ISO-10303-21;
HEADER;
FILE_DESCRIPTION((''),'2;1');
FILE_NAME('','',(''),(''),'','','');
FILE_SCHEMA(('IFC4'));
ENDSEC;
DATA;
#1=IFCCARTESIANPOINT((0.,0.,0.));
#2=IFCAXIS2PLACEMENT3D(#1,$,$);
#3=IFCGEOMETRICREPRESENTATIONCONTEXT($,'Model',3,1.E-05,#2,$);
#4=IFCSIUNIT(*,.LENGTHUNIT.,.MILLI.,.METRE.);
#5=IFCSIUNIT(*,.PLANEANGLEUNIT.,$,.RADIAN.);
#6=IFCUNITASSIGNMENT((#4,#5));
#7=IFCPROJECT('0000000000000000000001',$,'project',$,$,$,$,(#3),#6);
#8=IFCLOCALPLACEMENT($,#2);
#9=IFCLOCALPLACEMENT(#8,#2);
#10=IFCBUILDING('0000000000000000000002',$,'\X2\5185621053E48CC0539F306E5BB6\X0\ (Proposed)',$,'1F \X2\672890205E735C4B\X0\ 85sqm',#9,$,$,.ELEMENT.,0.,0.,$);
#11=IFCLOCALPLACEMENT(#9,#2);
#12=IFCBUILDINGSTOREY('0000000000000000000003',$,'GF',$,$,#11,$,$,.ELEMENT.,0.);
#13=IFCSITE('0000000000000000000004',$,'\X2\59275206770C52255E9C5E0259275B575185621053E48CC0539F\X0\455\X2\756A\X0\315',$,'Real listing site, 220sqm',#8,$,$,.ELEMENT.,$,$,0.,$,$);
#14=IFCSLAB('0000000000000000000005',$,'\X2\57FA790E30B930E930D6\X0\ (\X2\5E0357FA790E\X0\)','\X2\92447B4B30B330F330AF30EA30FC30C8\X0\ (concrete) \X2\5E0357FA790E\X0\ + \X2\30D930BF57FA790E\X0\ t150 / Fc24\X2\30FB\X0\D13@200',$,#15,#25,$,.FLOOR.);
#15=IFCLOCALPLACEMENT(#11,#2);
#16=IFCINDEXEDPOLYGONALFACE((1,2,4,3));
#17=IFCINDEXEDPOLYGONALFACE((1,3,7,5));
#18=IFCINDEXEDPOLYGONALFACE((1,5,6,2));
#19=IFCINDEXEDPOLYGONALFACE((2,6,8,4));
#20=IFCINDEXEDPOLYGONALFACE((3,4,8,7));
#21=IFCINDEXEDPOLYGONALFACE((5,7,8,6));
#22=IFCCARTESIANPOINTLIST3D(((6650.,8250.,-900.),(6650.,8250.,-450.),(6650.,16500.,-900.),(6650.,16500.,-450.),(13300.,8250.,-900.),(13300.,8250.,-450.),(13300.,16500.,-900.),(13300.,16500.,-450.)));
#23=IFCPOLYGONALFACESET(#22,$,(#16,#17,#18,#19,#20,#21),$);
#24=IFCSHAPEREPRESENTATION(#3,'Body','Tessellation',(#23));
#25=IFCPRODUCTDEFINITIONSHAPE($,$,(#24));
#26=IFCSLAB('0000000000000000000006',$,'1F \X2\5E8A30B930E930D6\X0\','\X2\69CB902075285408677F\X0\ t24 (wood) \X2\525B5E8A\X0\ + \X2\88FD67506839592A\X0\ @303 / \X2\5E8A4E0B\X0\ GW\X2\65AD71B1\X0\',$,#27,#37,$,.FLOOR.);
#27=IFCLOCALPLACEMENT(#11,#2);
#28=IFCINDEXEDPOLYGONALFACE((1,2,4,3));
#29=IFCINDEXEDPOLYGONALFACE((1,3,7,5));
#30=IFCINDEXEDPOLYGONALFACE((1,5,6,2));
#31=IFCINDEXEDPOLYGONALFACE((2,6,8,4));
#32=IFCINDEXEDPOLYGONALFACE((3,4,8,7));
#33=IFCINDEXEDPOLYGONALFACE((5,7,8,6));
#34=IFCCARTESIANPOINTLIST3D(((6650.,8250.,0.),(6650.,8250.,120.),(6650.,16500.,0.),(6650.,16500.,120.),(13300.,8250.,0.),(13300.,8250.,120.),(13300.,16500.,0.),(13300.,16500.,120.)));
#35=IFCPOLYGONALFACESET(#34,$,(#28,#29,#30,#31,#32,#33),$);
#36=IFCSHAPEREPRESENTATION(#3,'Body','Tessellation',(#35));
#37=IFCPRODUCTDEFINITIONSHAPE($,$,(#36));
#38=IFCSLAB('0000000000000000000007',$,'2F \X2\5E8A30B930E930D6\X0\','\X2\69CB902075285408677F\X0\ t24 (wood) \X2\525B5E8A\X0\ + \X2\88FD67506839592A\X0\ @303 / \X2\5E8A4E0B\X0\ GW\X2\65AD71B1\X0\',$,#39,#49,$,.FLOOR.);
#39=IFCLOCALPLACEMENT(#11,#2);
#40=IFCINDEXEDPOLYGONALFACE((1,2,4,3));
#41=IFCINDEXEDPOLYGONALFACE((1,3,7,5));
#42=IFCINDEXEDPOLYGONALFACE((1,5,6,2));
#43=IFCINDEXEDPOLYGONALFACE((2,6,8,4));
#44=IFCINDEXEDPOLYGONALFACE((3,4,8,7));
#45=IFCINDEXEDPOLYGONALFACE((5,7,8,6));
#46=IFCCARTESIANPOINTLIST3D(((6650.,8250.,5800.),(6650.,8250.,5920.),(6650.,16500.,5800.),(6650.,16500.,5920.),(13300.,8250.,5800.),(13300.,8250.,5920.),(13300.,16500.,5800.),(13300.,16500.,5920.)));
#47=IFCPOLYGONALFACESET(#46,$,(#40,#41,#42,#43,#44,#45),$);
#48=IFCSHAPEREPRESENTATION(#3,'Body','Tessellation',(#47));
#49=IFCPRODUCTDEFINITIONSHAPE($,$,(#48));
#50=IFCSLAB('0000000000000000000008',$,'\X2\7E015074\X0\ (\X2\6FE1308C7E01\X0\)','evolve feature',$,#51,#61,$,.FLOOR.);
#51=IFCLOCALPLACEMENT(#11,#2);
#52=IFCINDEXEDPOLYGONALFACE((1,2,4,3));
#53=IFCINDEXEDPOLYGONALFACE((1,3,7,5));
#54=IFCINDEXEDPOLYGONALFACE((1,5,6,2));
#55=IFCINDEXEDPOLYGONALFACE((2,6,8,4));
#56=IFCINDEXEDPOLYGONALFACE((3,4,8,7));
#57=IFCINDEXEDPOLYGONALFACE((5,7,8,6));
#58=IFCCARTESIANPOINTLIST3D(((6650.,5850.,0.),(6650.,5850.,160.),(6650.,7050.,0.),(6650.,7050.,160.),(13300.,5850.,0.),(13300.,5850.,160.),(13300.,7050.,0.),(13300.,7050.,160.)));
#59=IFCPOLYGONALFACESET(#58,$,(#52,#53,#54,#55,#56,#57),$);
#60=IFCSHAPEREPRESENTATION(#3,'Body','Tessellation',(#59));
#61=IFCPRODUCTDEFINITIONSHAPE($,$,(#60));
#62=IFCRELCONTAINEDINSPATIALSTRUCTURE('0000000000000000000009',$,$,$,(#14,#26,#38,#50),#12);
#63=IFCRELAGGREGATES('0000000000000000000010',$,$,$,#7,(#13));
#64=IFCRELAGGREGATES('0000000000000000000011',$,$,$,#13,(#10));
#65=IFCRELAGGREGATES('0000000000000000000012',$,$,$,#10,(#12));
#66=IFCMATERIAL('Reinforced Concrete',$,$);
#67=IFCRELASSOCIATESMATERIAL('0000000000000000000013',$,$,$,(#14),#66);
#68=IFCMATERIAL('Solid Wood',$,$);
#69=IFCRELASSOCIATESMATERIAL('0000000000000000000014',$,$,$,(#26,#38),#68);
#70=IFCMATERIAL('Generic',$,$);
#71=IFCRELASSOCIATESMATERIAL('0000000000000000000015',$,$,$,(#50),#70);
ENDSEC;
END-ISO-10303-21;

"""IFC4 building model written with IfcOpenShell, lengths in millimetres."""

from ifc_helpers import new_model, si_unit, frame, frame_2d, origin, place, context, project, spatial, rectangle, extrude, material, element, save


model = new_model("IFC4")

# Units and contexts
model_context = context("Model", 3, precision=1e-05, world=origin())
ifc_project = project(units=[si_unit("LENGTHUNIT", "METRE", prefix="MILLI"), si_unit("PLANEANGLEUNIT", "RADIAN")], contexts=[model_context])

# Site, building, storey
site_placement = place(None, origin())
site = spatial("IfcSite", under=ifc_project, at=site_placement, Name="大分県別府市大字内成古賀原455番315", ObjectType="Real listing site, 220sqm", CompositionType="ELEMENT", RefElevation=0.0)
building_placement = place(site_placement, origin())
building = spatial("IfcBuilding", under=site, at=building_placement, Name="内成古賀原の家 (Proposed)", ObjectType="1F 木造平屋 85sqm", CompositionType="ELEMENT", ElevationOfRefHeight=0.0, ElevationOfTerrain=0.0)
storey_placement = place(building_placement, origin())
storey = spatial("IfcBuildingStorey", under=building, at=storey_placement, Name="GF", CompositionType="ELEMENT", Elevation=0.0)

# Slabs
ifc_material_1 = material(Name="Reinforced Concrete")
slab_1_placement = place(storey_placement, frame((3325.0, 4125.0, -450.0)))
element("IfcSlab", 1, at=slab_1_placement, inside=storey, material=ifc_material_1, Name="基礎スラブ (布基礎)", Description="鉄筋コンクリート (concrete) 布基礎 + ベタ基礎 t150 / Fc24・D13@200", PredefinedType="FLOOR", context=model_context, shape_type="SweptSolid", body=[
    extrude(rectangle(XDim=6650.0, YDim=8250.0, at=frame_2d((3325.0, 4125.0))), frame((3325.0, 4125.0, -450.0)), (0.0, 0.0, 1.0), 450.0),
])
ifc_material_2 = material(Name="Solid Wood")
slab_2_placement = place(storey_placement, frame((3325.0, 4125.0, 0.0)))
element("IfcSlab", 2, at=slab_2_placement, inside=storey, material=ifc_material_2, Name="1F 床スラブ", Description="構造用合板 t24 (wood) 剛床 + 製材根太 @303 / 床下 GW断熱", PredefinedType="FLOOR", context=model_context, shape_type="SweptSolid", body=[
    extrude(rectangle(XDim=6650.0, YDim=8250.0, at=frame_2d((3325.0, 4125.0))), frame((3325.0, 4125.0, 0.0)), (0.0, 0.0, 1.0), 120.0),
])
slab_3_placement = place(storey_placement, frame((3325.0, 4125.0, 2900.0)))
element("IfcSlab", 3, at=slab_3_placement, inside=storey, material=ifc_material_2, Name="2F 床スラブ", Description="構造用合板 t24 (wood) 剛床 + 製材根太 @303 / 床下 GW断熱", PredefinedType="FLOOR", context=model_context, shape_type="SweptSolid", body=[
    extrude(rectangle(XDim=6650.0, YDim=8250.0, at=frame_2d((3325.0, 4125.0))), frame((3325.0, 4125.0, 2900.0)), (0.0, 0.0, 1.0), 120.0),
])
ifc_material_3 = material(Name="Generic")
slab_4_placement = place(storey_placement, frame((3325.0, 2925.0, 0.0)))
element("IfcSlab", 4, at=slab_4_placement, inside=storey, material=ifc_material_3, Name="縁側 (濡れ縁)", Description="evolve feature", PredefinedType="FLOOR", context=model_context, shape_type="SweptSolid", body=[
    extrude(rectangle(XDim=6650.0, YDim=1200.0, at=frame_2d((3325.0, 600.0))), frame((3325.0, 2925.0, 0.0)), (0.0, 0.0, 1.0), 160.0),
])

save(model, "model.ifc")
